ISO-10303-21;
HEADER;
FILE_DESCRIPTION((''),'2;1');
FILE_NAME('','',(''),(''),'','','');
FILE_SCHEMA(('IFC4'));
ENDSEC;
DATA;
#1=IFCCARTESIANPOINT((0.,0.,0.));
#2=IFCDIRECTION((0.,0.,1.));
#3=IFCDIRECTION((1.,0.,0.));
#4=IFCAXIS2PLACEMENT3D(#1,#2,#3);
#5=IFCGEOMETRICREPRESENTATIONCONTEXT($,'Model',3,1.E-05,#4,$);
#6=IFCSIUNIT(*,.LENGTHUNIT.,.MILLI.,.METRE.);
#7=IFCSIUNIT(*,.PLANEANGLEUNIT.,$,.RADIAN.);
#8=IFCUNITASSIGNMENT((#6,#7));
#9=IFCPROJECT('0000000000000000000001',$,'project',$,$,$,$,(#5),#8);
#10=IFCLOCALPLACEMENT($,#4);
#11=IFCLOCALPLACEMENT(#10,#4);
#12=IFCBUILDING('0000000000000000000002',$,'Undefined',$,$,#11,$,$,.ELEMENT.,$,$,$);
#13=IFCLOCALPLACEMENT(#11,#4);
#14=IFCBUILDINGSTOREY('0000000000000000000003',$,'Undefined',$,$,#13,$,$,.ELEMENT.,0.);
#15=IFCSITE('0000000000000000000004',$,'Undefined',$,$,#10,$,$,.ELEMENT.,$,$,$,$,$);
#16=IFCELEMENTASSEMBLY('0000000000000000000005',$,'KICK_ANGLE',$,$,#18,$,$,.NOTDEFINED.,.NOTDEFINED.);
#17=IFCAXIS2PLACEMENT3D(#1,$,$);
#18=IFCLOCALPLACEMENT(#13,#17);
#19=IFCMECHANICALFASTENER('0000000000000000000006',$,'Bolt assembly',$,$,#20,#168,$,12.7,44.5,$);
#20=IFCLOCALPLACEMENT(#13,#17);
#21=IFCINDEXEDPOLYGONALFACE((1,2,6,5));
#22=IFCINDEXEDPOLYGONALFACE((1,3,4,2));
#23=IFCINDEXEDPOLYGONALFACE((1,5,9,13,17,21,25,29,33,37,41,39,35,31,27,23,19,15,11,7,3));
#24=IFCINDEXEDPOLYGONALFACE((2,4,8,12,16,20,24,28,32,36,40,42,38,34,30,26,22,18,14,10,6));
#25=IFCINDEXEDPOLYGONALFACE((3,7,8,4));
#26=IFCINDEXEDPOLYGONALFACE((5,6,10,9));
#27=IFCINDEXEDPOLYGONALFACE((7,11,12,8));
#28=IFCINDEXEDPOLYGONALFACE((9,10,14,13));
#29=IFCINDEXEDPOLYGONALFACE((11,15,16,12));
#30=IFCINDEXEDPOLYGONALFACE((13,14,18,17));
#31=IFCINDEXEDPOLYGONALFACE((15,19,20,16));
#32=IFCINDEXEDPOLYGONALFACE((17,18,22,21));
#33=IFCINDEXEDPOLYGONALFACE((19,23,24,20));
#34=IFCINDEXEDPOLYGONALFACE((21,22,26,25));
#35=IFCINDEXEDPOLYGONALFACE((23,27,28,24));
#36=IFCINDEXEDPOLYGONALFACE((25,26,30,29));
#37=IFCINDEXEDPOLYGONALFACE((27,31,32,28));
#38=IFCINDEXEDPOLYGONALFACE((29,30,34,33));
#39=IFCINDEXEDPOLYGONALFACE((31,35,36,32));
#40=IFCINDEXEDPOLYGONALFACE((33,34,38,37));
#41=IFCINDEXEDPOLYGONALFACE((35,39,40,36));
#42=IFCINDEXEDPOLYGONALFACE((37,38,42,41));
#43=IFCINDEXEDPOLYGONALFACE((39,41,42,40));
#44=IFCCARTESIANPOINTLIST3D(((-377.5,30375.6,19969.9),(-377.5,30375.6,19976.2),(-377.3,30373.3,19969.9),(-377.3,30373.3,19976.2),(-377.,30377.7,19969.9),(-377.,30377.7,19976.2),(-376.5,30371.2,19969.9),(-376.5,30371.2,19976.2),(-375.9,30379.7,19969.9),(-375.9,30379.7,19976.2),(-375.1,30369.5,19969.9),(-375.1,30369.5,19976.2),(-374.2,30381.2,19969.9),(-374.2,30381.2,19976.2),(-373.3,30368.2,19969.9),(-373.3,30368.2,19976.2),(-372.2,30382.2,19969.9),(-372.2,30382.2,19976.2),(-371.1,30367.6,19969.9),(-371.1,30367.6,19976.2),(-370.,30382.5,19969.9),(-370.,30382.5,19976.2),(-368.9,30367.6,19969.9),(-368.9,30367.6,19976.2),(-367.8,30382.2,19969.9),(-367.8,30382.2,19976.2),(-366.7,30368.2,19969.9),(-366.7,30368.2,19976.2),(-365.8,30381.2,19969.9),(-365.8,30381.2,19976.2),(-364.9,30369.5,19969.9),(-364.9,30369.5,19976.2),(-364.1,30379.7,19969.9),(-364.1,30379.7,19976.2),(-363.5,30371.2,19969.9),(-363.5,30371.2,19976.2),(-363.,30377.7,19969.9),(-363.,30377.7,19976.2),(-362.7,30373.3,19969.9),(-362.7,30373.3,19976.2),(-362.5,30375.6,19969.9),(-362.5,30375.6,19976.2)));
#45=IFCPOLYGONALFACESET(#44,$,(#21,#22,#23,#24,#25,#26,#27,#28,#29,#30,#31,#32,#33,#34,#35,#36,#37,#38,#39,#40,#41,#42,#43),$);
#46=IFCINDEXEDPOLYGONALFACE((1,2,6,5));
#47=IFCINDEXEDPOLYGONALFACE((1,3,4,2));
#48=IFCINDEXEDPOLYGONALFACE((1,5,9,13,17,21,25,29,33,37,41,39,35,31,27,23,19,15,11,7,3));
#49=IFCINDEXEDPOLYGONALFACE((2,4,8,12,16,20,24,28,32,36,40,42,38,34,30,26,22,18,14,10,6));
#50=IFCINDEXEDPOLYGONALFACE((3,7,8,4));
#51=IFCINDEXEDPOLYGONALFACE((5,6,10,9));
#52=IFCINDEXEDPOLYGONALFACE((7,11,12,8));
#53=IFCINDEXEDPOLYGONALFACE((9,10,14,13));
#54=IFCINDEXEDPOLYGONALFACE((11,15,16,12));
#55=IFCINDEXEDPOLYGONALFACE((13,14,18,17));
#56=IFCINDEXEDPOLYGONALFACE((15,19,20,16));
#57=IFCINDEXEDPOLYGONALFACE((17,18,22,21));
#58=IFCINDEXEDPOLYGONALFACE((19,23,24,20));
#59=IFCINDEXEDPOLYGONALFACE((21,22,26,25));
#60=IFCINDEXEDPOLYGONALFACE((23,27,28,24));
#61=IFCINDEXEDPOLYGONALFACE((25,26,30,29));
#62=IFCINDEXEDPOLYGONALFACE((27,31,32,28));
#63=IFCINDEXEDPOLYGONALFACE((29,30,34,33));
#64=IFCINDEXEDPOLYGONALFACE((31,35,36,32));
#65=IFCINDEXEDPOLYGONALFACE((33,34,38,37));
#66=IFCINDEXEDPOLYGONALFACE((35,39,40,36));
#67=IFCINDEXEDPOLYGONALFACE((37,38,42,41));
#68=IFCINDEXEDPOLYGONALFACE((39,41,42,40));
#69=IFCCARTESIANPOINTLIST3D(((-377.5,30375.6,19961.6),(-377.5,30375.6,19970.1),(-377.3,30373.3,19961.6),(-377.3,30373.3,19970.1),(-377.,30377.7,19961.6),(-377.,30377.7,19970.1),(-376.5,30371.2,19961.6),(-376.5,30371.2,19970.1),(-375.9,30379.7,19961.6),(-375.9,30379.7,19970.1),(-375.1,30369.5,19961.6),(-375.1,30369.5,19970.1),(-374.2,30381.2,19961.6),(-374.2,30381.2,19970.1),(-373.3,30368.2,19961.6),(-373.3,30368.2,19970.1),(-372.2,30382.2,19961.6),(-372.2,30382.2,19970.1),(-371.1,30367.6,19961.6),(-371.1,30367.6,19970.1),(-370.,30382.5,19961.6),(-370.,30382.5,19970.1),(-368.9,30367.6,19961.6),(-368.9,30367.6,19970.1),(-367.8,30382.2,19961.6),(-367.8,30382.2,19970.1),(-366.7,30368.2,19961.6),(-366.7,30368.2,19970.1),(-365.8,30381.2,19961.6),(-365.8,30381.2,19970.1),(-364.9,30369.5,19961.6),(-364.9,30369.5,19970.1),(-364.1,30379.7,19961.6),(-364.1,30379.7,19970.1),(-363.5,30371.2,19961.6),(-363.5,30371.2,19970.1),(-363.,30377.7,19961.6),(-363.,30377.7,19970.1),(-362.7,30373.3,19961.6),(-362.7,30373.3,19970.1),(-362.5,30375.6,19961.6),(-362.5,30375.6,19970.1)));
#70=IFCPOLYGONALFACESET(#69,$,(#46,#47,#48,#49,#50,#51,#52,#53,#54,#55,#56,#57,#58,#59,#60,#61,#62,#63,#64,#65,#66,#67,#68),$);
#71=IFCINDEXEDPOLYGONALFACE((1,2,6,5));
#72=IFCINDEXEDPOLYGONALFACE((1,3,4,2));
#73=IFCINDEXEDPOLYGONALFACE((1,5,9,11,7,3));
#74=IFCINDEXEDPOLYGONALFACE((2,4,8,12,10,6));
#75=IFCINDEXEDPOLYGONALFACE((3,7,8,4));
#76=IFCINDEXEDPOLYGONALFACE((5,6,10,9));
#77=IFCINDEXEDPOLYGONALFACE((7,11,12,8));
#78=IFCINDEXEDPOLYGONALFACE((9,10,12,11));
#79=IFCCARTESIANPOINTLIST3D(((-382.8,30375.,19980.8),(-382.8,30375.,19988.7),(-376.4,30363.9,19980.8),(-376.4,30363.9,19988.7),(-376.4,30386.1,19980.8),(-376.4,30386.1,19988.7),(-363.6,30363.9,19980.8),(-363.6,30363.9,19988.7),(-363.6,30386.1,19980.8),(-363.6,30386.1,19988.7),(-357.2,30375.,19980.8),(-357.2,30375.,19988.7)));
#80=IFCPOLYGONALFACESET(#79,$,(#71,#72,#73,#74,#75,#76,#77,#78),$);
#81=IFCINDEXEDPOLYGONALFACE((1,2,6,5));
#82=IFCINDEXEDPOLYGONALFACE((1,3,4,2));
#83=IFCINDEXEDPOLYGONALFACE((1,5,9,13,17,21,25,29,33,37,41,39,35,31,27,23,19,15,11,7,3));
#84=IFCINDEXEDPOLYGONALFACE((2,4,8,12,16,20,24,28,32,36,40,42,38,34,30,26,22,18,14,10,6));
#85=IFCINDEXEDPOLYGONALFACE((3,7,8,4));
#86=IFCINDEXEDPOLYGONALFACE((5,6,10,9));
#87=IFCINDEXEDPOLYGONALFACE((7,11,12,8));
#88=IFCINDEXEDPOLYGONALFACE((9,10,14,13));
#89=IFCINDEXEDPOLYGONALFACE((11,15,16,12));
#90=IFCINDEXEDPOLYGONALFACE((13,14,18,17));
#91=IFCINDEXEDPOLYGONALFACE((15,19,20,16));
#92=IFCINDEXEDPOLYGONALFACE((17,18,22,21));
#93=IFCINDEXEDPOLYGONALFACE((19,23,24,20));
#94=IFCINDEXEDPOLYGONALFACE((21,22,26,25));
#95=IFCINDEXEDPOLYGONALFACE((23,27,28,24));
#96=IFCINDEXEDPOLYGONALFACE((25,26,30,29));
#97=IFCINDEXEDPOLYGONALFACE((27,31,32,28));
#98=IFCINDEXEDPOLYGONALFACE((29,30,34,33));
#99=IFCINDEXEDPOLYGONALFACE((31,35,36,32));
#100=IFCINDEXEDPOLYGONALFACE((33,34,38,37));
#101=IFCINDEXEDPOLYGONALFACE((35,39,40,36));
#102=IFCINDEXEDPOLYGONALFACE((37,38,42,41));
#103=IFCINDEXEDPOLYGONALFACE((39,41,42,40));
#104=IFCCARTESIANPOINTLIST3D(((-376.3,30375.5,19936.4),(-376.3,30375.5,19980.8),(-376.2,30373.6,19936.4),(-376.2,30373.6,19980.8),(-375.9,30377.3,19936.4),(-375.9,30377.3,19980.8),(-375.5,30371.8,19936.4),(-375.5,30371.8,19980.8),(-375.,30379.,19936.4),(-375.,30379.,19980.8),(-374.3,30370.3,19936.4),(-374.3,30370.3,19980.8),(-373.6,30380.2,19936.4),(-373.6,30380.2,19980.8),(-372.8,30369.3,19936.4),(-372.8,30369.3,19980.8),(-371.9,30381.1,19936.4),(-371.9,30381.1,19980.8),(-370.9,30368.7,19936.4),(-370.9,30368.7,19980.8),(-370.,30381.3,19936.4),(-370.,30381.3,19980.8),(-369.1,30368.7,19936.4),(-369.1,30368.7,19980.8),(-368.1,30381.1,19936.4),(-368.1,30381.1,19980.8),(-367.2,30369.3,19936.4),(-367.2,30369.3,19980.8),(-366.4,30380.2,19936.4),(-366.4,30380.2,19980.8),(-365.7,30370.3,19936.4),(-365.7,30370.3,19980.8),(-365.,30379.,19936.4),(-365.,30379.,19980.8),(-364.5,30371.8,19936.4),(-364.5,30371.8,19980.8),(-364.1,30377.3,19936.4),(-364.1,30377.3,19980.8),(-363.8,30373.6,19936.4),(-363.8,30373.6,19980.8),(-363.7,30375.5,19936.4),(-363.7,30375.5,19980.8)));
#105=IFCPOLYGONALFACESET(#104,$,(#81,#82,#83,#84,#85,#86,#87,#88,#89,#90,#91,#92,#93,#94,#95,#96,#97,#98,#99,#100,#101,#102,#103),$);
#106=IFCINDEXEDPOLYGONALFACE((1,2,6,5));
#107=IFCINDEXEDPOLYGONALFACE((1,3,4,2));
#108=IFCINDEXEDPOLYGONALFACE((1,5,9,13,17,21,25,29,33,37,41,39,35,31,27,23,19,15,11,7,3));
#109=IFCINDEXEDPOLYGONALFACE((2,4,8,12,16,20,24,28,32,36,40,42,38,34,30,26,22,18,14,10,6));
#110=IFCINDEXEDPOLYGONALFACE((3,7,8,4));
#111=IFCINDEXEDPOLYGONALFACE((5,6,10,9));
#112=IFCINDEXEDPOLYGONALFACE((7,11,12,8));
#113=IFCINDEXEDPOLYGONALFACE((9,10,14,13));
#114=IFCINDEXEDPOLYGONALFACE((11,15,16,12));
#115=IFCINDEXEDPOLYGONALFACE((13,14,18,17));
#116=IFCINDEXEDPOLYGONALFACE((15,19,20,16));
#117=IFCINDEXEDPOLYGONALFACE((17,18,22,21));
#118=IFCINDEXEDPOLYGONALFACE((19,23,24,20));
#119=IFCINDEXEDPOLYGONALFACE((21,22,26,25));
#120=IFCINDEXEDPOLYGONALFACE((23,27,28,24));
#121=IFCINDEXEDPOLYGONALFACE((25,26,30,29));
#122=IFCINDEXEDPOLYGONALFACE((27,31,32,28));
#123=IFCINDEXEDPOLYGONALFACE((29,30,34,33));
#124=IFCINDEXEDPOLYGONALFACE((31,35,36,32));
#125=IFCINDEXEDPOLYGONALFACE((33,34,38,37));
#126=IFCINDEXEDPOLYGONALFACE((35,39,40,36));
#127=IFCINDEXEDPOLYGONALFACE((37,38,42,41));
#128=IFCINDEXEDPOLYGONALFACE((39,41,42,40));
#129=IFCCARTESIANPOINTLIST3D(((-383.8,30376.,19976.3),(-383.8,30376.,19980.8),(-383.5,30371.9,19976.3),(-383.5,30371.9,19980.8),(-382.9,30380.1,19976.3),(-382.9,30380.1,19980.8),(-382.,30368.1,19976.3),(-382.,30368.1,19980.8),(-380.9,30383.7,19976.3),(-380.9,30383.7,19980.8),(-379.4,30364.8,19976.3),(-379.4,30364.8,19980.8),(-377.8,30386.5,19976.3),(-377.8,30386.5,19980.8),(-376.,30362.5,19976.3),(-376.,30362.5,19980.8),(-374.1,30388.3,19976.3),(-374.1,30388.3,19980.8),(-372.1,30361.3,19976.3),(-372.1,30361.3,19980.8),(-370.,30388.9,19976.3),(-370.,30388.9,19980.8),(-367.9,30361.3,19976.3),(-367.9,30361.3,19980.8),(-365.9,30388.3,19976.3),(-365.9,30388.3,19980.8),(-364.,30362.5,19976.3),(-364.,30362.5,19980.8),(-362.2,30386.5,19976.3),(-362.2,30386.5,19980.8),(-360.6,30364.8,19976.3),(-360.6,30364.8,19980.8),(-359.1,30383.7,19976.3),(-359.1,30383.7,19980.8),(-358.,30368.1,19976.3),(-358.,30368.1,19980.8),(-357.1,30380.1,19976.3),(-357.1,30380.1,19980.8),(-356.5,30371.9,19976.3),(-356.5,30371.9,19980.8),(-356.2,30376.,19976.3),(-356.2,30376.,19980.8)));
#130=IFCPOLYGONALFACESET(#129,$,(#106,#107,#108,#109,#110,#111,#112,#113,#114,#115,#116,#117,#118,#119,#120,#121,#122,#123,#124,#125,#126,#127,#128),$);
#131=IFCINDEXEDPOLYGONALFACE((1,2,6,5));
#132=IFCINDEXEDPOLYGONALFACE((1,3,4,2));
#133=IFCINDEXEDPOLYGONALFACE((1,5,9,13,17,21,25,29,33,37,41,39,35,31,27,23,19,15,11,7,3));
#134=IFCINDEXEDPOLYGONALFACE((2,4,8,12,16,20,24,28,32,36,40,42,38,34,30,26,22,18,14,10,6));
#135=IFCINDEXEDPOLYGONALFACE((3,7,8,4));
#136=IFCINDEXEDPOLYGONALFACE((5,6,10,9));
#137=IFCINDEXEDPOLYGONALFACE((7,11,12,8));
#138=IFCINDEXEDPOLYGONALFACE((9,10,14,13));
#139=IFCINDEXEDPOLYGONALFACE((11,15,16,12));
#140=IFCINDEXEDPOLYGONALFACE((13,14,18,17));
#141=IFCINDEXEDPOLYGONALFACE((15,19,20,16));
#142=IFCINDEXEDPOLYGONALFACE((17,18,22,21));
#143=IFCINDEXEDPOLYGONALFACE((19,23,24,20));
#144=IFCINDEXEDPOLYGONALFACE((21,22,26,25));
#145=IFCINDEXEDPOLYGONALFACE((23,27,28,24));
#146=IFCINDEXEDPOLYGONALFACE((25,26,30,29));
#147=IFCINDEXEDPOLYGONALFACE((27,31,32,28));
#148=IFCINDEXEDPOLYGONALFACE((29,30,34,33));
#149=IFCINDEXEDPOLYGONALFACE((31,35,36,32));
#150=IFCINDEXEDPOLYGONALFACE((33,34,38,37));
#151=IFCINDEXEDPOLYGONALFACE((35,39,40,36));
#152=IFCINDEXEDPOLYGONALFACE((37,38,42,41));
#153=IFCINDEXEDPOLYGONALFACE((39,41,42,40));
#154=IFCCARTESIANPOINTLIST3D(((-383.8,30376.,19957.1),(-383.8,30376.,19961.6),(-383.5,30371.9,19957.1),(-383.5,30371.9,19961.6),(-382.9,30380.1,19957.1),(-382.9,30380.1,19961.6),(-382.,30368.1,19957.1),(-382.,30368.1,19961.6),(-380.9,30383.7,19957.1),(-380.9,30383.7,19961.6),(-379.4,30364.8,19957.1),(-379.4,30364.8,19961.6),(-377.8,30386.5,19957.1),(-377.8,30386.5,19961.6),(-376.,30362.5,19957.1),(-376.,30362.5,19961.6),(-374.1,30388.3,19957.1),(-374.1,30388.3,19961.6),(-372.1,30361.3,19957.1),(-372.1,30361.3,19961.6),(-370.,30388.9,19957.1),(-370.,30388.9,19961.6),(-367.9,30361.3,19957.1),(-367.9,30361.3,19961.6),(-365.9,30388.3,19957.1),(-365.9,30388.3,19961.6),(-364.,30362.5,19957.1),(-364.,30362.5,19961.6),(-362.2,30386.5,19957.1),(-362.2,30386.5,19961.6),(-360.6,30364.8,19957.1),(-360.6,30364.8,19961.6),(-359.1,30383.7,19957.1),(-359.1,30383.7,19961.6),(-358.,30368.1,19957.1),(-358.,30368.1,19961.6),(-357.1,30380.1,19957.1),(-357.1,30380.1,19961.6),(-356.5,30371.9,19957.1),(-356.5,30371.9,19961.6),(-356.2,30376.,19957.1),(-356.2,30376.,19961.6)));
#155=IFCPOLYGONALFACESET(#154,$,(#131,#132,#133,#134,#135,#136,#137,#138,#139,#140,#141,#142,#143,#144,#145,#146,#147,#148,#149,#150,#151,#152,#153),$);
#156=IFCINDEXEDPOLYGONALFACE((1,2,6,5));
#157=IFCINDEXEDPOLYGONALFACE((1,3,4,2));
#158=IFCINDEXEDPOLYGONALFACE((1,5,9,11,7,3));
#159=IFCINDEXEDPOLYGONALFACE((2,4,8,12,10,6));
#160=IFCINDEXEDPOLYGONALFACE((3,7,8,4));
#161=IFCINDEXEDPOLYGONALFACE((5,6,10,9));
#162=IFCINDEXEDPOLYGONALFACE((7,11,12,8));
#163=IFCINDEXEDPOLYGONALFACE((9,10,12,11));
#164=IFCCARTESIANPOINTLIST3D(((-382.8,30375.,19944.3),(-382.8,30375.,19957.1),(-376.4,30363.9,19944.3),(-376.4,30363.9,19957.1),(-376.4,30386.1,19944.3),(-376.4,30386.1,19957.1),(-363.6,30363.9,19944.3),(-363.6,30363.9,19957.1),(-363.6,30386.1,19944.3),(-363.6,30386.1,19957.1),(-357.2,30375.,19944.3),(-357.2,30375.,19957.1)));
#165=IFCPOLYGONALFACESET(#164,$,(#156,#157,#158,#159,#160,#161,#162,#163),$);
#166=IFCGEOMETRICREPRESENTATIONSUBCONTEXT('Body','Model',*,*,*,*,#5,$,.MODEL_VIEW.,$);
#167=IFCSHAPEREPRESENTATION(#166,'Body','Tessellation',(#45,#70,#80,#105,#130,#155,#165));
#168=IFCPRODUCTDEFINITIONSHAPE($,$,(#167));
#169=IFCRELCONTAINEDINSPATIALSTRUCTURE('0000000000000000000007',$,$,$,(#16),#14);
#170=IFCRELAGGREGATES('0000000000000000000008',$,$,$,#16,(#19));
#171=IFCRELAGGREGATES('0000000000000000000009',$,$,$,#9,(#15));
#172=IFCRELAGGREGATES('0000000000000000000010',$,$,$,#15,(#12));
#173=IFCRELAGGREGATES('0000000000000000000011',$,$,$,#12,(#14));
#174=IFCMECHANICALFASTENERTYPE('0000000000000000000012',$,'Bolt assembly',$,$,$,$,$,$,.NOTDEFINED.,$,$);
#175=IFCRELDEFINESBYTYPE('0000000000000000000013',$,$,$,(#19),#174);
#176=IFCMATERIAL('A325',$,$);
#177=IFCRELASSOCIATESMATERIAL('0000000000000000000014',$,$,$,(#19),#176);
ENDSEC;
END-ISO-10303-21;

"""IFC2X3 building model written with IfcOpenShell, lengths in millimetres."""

from ifc_helpers import new_model, si_unit, frame, origin_with_axes, origin_2d_with_axis, place, context, subcontext, project, spatial, polyline, circle, outline, extrude, source, transform, mapped, material, type_object, element, aggregate, save


model = new_model("IFC2X3")

# Units and contexts
model_context = context("Model", 3, precision=1e-05, world=origin_with_axes())
body_context = subcontext(model_context, "Body", "Model", "MODEL_VIEW")
ifc_project = project(units=[si_unit("LENGTHUNIT", "METRE", prefix="MILLI"), si_unit("PLANEANGLEUNIT", "RADIAN")], contexts=[model_context])

# Site, building, storey
site_placement = place(None, origin_with_axes())
site = spatial("IfcSite", under=ifc_project, at=site_placement, Name="Undefined", CompositionType="ELEMENT")
building_placement = place(site_placement, origin_with_axes())
building = spatial("IfcBuilding", under=site, at=building_placement, Name="Undefined", CompositionType="ELEMENT")
storey_placement = place(building_placement, origin_with_axes())
storey = spatial("IfcBuildingStorey", under=building, at=storey_placement, Name="Undefined", CompositionType="ELEMENT", Elevation=0.0)

# Element assembly
assembly_1_placement = place(storey_placement, origin_with_axes())
assembly_1 = element("IfcElementAssembly", 1, at=assembly_1_placement, inside=storey, Name="KICK_ANGLE", AssemblyPlace="NOTDEFINED", PredefinedType="NOTDEFINED")

# Shared definitions
ifc_material_1 = material(Name="A325")
mechanical_fastener_type = type_object("IfcMechanicalFastenerType", Name="Bolt assembly")

# Mechanical fastener
shared_shape_1 = source(origin_with_axes(), body_context, "Body", "SweptSolid", [
    extrude(circle(Radius=7.5, at=origin_2d_with_axis()), frame((0.0, -6.2, 0.0), z_axis=(0.0, 1.0, 0.0), x_axis=(1.0, 0.0, 0.0)), (0.0, 0.0, 1.0), 6.3),
    extrude(circle(Radius=7.5, at=origin_2d_with_axis()), frame((0.0, -0.1, 0.0), z_axis=(0.0, 1.0, 0.0), x_axis=(1.0, 0.0, 0.0)), (0.0, 0.0, 1.0), 8.5),
    extrude(outline(polyline([(11.1, -6.4), (11.1, 6.4), (0.0, 12.8), (-11.1, 6.4), (-11.1, -6.4), (0.0, -12.8), (11.1, -6.4)])), frame((0.0, -18.7, 0.0), z_axis=(0.0, 1.0, 0.0), x_axis=(1.0, 0.0, 0.0)), (0.0, 0.0, 1.0), 7.9),
    extrude(circle(Radius=6.3, at=origin_2d_with_axis()), frame((0.0, -10.8, 0.0), z_axis=(0.0, 1.0, 0.0), x_axis=(1.0, 0.0, 0.0)), (0.0, 0.0, 1.0), 44.5),
    extrude(circle(Radius=13.9, at=origin_2d_with_axis()), frame((0.0, -10.8, 0.0), z_axis=(0.0, 1.0, 0.0), x_axis=(1.0, 0.0, 0.0)), (0.0, 0.0, 1.0), 4.5),
    extrude(circle(Radius=13.9, at=origin_2d_with_axis()), frame((0.0, 8.4, 0.0), z_axis=(0.0, 1.0, 0.0), x_axis=(1.0, 0.0, 0.0)), (0.0, 0.0, 1.0), 4.5),
    extrude(outline(polyline([(11.1, -6.4), (11.1, 6.4), (0.0, 12.8), (-11.1, 6.4), (-11.1, -6.4), (0.0, -12.8), (11.1, -6.4)])), frame((0.0, 12.9, 0.0), z_axis=(0.0, 1.0, 0.0), x_axis=(1.0, 0.0, 0.0)), (0.0, 0.0, 1.0), 12.8),
])
mechanical_fastener_1_placement = place(assembly_1_placement, frame((-370.0, 30410.0, 19970.0), z_axis=(-1.0, 0.0, 0.0), x_axis=(0.0, 1.0, 0.0)))
mechanical_fastener_1 = element("IfcMechanicalFastener", 2, at=mechanical_fastener_1_placement, type_object=mechanical_fastener_type, material=ifc_material_1, Name="Bolt assembly", NominalDiameter=12.7, NominalLength=44.5, context=body_context, shape_type="MappedRepresentation", body=[
    mapped(shared_shape_1, transform((-35.0, 0.0, 0.0))),
])
aggregate(assembly_1, [mechanical_fastener_1])

save(model, "model.ifc")
